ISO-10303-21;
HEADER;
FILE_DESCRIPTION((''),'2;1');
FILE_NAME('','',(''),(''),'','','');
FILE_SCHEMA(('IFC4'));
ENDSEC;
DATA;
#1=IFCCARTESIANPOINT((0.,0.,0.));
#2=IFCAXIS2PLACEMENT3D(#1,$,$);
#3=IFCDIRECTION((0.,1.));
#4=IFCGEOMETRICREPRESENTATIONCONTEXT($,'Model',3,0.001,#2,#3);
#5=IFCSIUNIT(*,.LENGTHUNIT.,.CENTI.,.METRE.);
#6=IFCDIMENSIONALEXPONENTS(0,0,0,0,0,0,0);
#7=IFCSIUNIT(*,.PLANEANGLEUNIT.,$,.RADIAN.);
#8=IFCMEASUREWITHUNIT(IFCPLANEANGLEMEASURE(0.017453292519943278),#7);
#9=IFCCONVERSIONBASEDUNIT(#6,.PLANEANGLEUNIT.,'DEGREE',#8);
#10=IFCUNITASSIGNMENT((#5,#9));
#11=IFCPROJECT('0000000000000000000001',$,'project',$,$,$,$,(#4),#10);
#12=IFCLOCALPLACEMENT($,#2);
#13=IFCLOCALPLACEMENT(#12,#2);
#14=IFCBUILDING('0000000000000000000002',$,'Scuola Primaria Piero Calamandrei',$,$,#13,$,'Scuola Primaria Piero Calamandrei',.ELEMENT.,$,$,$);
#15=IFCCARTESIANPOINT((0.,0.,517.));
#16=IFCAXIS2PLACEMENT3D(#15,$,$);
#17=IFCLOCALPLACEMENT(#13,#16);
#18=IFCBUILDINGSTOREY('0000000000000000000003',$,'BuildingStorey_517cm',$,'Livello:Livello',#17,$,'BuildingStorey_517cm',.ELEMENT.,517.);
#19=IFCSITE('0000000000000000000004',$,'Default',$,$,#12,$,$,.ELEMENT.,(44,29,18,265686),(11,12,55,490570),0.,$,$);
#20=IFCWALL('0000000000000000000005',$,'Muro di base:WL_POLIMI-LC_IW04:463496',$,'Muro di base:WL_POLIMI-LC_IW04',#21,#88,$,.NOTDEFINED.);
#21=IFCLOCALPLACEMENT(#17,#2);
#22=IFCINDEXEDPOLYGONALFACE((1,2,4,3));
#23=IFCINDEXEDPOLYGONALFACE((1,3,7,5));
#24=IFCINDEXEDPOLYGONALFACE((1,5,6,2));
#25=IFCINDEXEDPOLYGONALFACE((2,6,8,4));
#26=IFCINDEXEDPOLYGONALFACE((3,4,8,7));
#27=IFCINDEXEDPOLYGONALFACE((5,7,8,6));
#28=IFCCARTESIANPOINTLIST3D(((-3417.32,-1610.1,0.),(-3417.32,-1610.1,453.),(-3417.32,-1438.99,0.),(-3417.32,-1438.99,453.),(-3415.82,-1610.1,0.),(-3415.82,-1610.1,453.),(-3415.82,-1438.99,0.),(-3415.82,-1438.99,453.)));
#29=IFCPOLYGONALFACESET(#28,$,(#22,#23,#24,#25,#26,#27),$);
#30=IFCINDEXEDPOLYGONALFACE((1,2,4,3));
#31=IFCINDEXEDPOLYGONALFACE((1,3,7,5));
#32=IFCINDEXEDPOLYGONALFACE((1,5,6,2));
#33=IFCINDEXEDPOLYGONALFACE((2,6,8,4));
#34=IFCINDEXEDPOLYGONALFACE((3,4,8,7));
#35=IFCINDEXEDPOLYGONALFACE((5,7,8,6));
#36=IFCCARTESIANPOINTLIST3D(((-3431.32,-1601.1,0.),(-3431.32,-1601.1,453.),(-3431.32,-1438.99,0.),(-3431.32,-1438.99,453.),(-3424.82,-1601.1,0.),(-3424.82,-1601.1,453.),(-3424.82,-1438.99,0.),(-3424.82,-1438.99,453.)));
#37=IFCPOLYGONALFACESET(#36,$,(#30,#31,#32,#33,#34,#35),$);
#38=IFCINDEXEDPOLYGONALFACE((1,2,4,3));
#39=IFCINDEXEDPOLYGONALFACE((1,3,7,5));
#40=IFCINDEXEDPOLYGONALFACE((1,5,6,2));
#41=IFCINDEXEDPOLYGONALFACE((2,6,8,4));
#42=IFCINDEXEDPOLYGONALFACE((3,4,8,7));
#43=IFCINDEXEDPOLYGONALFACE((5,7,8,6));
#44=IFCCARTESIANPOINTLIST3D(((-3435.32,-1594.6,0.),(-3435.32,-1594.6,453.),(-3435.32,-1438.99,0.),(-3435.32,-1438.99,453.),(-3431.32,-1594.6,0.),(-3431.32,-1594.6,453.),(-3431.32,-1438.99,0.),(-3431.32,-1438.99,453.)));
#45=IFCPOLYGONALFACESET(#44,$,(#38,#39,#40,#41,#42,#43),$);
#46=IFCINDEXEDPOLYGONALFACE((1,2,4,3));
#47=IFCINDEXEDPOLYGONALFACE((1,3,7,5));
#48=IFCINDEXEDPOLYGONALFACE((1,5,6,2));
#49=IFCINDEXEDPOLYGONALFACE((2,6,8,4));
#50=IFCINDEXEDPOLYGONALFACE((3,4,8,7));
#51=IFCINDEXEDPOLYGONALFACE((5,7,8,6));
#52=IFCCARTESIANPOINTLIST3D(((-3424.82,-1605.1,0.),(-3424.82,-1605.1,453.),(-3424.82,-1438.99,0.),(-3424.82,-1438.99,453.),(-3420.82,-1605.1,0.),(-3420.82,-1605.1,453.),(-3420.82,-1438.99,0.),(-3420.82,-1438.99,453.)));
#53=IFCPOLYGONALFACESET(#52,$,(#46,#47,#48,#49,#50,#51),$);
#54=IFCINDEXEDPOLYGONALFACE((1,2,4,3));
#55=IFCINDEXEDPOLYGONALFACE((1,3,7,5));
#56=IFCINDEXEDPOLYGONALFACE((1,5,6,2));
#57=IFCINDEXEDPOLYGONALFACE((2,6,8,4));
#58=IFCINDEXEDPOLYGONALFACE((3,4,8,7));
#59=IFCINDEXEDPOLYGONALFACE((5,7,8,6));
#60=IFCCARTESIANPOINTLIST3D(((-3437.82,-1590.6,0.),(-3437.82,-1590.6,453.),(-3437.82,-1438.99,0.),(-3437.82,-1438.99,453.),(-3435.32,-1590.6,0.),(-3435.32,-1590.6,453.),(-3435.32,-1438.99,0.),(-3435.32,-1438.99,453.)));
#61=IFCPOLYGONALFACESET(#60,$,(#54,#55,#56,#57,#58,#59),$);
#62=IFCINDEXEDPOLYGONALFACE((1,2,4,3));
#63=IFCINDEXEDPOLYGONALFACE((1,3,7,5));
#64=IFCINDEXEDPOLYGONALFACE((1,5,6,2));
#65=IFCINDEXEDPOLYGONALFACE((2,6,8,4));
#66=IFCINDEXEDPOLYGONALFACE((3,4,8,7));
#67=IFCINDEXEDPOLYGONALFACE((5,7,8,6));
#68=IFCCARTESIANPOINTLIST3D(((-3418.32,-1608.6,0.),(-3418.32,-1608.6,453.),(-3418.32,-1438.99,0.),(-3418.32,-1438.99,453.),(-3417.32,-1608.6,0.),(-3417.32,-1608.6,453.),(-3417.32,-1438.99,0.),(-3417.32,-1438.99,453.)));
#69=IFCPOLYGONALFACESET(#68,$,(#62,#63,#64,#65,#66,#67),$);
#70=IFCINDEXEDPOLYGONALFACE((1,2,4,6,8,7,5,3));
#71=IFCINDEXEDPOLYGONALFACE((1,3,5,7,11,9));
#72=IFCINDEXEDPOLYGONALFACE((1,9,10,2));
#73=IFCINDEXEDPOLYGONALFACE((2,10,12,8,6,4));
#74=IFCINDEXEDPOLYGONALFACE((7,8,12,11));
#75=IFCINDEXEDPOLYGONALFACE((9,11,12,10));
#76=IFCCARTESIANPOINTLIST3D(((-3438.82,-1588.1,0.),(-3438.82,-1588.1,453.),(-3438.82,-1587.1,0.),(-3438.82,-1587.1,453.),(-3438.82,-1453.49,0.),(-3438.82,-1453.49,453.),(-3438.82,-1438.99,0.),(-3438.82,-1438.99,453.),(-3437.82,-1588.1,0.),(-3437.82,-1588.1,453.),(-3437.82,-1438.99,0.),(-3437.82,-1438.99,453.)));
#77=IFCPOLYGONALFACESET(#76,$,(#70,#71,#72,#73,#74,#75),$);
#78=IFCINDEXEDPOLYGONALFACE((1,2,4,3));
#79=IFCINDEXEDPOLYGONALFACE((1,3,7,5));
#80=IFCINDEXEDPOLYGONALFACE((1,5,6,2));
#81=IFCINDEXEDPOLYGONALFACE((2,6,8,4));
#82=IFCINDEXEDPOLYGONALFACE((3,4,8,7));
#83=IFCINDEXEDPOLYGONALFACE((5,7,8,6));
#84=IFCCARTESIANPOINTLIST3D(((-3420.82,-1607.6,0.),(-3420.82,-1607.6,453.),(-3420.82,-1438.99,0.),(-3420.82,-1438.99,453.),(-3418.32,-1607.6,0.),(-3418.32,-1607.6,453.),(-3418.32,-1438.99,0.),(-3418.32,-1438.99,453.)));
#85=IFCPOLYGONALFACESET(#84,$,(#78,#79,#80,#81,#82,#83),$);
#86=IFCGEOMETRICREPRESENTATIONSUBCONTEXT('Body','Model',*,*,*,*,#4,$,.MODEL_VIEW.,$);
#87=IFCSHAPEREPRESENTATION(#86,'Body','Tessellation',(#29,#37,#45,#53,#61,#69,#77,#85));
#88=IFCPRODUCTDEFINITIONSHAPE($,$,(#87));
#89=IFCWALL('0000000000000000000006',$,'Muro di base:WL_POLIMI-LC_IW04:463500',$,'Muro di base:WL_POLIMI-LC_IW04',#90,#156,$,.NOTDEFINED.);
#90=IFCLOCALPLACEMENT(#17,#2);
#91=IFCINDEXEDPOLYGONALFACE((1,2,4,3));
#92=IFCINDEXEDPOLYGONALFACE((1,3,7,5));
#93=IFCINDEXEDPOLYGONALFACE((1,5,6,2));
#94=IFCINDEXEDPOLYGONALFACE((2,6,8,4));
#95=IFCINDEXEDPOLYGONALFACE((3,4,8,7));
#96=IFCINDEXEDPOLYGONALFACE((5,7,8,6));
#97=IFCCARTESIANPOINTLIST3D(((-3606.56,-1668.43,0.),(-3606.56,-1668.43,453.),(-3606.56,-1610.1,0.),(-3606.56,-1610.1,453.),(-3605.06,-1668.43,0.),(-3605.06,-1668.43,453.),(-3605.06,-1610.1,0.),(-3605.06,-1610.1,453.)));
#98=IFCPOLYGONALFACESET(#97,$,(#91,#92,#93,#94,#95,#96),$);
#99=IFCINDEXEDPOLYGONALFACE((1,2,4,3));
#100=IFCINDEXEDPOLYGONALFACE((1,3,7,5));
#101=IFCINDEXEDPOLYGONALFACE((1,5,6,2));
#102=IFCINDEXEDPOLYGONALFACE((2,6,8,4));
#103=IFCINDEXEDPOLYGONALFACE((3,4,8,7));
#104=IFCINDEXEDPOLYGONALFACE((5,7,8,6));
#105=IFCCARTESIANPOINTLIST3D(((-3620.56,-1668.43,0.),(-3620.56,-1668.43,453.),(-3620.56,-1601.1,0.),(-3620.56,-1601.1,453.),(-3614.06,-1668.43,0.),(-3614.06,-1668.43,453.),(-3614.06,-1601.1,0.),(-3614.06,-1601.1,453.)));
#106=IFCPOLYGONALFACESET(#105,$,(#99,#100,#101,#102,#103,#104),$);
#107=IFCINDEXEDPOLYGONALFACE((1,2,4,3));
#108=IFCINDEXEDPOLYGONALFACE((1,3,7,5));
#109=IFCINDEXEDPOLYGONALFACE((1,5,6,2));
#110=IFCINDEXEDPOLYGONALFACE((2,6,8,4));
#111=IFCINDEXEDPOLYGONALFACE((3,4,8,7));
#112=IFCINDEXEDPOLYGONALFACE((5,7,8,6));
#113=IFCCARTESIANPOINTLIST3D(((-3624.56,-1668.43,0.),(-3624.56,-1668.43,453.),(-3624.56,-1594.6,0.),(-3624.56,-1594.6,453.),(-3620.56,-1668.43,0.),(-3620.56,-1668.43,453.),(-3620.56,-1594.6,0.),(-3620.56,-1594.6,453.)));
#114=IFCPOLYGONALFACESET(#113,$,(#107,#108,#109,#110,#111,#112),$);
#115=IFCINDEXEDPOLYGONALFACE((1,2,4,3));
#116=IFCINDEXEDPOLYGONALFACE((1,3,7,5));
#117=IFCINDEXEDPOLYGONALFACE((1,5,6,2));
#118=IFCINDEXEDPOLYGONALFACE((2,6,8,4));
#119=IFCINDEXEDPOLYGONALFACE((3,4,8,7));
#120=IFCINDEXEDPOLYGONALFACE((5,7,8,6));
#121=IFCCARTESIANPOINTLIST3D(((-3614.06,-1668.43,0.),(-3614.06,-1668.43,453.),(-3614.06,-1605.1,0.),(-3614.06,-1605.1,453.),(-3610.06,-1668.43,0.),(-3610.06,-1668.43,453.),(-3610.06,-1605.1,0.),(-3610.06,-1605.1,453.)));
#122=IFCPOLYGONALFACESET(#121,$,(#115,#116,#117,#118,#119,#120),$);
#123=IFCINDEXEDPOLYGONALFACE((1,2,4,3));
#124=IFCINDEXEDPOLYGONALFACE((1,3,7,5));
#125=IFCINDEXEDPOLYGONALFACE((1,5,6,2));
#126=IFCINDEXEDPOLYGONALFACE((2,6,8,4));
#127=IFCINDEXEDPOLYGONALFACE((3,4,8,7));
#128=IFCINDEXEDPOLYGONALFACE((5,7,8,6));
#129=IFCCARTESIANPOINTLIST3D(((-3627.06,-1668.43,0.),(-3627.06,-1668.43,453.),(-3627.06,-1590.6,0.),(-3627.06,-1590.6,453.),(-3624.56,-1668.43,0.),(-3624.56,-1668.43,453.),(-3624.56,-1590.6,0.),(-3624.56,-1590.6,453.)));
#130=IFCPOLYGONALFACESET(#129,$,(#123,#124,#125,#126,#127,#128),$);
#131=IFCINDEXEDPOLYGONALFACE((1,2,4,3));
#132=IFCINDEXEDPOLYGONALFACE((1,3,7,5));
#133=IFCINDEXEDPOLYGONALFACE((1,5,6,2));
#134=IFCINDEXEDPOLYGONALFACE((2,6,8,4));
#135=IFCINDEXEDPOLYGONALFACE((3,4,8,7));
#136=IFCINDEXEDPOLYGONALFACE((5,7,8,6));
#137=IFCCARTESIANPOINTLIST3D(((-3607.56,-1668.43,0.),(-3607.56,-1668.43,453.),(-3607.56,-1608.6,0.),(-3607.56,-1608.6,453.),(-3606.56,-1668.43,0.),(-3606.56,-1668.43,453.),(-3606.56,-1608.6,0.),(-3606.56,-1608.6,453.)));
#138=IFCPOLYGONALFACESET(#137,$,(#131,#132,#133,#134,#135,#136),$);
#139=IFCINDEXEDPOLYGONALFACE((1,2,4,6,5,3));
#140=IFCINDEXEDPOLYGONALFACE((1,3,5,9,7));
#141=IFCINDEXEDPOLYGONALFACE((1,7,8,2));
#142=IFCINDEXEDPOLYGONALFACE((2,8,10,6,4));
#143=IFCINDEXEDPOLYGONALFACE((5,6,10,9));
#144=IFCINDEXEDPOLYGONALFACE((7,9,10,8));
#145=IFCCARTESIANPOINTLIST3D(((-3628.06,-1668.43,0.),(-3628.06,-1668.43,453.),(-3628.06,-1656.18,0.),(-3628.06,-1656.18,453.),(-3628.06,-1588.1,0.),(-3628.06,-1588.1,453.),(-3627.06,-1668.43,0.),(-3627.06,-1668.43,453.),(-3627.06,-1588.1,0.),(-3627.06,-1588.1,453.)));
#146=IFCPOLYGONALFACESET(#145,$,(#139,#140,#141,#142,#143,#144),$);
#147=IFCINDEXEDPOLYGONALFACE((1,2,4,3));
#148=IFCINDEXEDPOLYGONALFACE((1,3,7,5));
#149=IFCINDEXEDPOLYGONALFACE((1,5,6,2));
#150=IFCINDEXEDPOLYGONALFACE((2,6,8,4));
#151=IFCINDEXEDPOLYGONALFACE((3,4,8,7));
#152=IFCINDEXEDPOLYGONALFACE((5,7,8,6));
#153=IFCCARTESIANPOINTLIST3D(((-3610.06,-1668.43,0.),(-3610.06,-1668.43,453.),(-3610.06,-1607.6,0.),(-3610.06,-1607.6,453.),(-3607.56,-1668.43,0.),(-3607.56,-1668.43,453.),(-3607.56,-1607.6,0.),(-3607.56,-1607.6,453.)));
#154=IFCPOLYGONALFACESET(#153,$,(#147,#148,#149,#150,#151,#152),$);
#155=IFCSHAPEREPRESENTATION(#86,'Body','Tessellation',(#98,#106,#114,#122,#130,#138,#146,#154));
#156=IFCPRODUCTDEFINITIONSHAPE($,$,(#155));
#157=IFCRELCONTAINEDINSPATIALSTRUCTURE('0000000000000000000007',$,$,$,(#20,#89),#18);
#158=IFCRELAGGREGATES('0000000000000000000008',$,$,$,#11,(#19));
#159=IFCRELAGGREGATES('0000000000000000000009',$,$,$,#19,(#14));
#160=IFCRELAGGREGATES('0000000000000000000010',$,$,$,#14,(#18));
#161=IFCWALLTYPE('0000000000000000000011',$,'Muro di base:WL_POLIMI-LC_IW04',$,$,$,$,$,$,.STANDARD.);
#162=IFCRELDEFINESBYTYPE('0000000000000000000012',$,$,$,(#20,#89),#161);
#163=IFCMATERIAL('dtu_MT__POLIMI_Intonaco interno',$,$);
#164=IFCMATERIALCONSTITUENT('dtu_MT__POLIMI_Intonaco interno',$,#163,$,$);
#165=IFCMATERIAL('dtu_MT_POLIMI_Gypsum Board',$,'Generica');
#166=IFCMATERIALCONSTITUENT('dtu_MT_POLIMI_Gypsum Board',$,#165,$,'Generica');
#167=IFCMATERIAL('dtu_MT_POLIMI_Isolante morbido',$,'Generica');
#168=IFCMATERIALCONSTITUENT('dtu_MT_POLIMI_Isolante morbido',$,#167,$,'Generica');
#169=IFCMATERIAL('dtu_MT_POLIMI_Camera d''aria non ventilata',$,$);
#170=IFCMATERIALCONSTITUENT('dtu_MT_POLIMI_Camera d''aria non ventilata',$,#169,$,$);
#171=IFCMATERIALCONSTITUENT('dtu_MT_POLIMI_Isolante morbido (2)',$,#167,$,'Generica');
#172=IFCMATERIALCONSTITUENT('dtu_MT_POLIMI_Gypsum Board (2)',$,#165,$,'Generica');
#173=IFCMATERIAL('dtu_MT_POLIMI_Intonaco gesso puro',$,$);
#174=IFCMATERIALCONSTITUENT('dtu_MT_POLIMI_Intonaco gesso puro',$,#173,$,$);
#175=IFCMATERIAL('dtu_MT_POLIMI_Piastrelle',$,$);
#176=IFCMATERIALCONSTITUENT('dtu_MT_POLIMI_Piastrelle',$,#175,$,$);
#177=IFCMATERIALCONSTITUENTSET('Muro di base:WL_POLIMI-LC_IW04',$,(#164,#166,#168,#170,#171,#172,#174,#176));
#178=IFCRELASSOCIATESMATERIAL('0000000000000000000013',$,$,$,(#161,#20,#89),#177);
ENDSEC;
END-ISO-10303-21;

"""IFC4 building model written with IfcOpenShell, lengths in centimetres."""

from ifc_helpers import new_model, entity, si_unit, converted_unit, direction, frame, origin, place, context, subcontext, project, spatial, indexed_curve, outline, extrude, material, constituent, constituent_set, type_object, element, save


model = new_model("IFC4")

# Units and contexts
model_context = context("Model", 3, precision=0.001, world=origin(), true_north=direction((0.0, 1.0)))
body_context = subcontext(model_context, "Body", "Model", "MODEL_VIEW")
ifc_project = project(units=[si_unit("LENGTHUNIT", "METRE", prefix="CENTI"), converted_unit("PLANEANGLEUNIT", "DEGREE", entity("IfcPlaneAngleMeasure", 0.017453292519943278), si_unit("PLANEANGLEUNIT", "RADIAN"), dimensions=[0, 0, 0, 0, 0, 0, 0])], contexts=[model_context])

# Site, building, storey
site_placement = place(None, origin())
site = spatial("IfcSite", under=ifc_project, at=site_placement, Name="Default", CompositionType="ELEMENT", RefLatitude=(44, 29, 18, 265686), RefLongitude=(11, 12, 55, 490570), RefElevation=0.0)
building_placement = place(site_placement, origin())
building = spatial("IfcBuilding", under=site, at=building_placement, Name="Scuola Primaria Piero Calamandrei", LongName="Scuola Primaria Piero Calamandrei", CompositionType="ELEMENT")
storey_placement = place(building_placement, frame((0.0, 0.0, 517.0)))
storey = spatial("IfcBuildingStorey", under=building, at=storey_placement, Name="BuildingStorey_517cm", ObjectType="Livello:Livello", LongName="BuildingStorey_517cm", CompositionType="ELEMENT", Elevation=517.0)

# Shared definitions
ifc_material_1 = material(Name="dtu_MT_POLIMI_Isolante morbido", Category="Generica")
ifc_material_2 = material(Name="dtu_MT_POLIMI_Gypsum Board", Category="Generica")
ifc_material_3 = material(Name="dtu_MT__POLIMI_Intonaco interno")

# Wall
ifc_constituent_1 = constituent(ifc_material_3, Name="dtu_MT__POLIMI_Intonaco interno")
ifc_constituent_2 = constituent(ifc_material_2, Name="dtu_MT_POLIMI_Gypsum Board", Category="Generica")
ifc_constituent_3 = constituent(ifc_material_1, Name="dtu_MT_POLIMI_Isolante morbido", Category="Generica")
ifc_material_4 = material(Name="dtu_MT_POLIMI_Camera d'aria non ventilata")
ifc_constituent_4 = constituent(ifc_material_4, Name="dtu_MT_POLIMI_Camera d'aria non ventilata")
ifc_constituent_5 = constituent(ifc_material_1, Name="dtu_MT_POLIMI_Isolante morbido (2)", Category="Generica")
ifc_constituent_6 = constituent(ifc_material_2, Name="dtu_MT_POLIMI_Gypsum Board (2)", Category="Generica")
ifc_material_5 = material(Name="dtu_MT_POLIMI_Intonaco gesso puro")
ifc_constituent_7 = constituent(ifc_material_5, Name="dtu_MT_POLIMI_Intonaco gesso puro")
ifc_material_6 = material(Name="dtu_MT_POLIMI_Piastrelle")
ifc_constituent_8 = constituent(ifc_material_6, Name="dtu_MT_POLIMI_Piastrelle")
ifc_constituent_set_1 = constituent_set(constituents=[ifc_constituent_1, ifc_constituent_2, ifc_constituent_3, ifc_constituent_4, ifc_constituent_5, ifc_constituent_6, ifc_constituent_7, ifc_constituent_8], Name="Muro di base:WL_POLIMI-LC_IW04")
wall_type_1 = type_object("IfcWallType", Name="Muro di base:WL_POLIMI-LC_IW04", PredefinedType="STANDARD", material=ifc_constituent_set_1)
wall_1_placement = place(storey_placement, frame((-3427.32, -1610.1, 0.0), z_axis=(0.0, 0.0, 1.0), x_axis=(0.0, 1.0, 0.0)))
element("IfcWall", 1, at=wall_1_placement, inside=storey, type_object=wall_type_1, material=ifc_constituent_set_1, Name="Muro di base:WL_POLIMI-LC_IW04:463496", ObjectType="Muro di base:WL_POLIMI-LC_IW04", PredefinedType="NOTDEFINED", context=body_context, shape_type="SweptSolid", body=[
    extrude(outline(indexed_curve([(-0.75, -85.55), (0.75, -85.55), (0.75, 85.55), (-0.75, 85.55), (-0.75, -85.55)], self_intersect=False)), frame((85.55, -10.75, 0.0), z_axis=(0.0, 0.0, 1.0), x_axis=(0.0, 1.0, 0.0)), (0.0, 0.0, 1.0), 453.0),
    extrude(outline(indexed_curve([(-81.05, -3.25), (81.05, -3.25), (81.05, 3.25), (-81.05, 3.25), (-81.05, -3.25)], self_intersect=False)), frame((90.05, 0.75, 0.0)), (0.0, 0.0, 1.0), 453.0),
    extrude(outline(indexed_curve([(-77.8, -2.0), (77.8, -2.0), (77.8, 2.0), (-77.8, 2.0), (-77.8, -2.0)], self_intersect=False)), frame((93.3, 6.0, 0.0)), (0.0, 0.0, 1.0), 453.0),
    extrude(outline(indexed_curve([(-83.05, -2.0), (83.05, -2.0), (83.05, 2.0), (-83.05, 2.0), (-83.05, -2.0)], self_intersect=False)), frame((88.05, -4.5, 0.0)), (0.0, 0.0, 1.0), 453.0),
    extrude(outline(indexed_curve([(-75.8, -1.25), (75.8, -1.25), (75.8, 1.25), (-75.8, 1.25), (-75.8, -1.25)], self_intersect=False)), frame((95.3, 9.25, 0.0)), (0.0, 0.0, 1.0), 453.0),
    extrude(outline(indexed_curve([(-84.8, -0.5), (84.8, -0.5), (84.8, 0.5), (-84.8, 0.5), (-84.8, -0.5)], self_intersect=False)), frame((86.3, -9.5, 0.0)), (0.0, 0.0, 1.0), 453.0),
    extrude(outline(indexed_curve([(-62.3, -0.33), (71.3, -0.33), (72.3, -0.33), (72.3, 0.67), (-76.8, 0.67), (-76.8, -0.33), (-62.3, -0.33)], self_intersect=False)), frame((94.3, 11.17, 0.0), z_axis=(0.0, 0.0, 1.0), x_axis=(-1.0, 0.0, 0.0)), (0.0, 0.0, 1.0), 453.0),
    extrude(outline(indexed_curve([(-84.3, -1.25), (84.3, -1.25), (84.3, 1.25), (-84.3, 1.25), (-84.3, -1.25)], self_intersect=False)), frame((86.8, -7.75, 0.0)), (0.0, 0.0, 1.0), 453.0),
])

# Wall
wall_2_placement = place(storey_placement, frame((-3616.56, -1668.43, 0.0), z_axis=(0.0, 0.0, 1.0), x_axis=(0.0, 1.0, 0.0)))
element("IfcWall", 2, at=wall_2_placement, inside=storey, type_object=wall_type_1, material=ifc_constituent_set_1, Name="Muro di base:WL_POLIMI-LC_IW04:463500", ObjectType="Muro di base:WL_POLIMI-LC_IW04", PredefinedType="NOTDEFINED", context=body_context, shape_type="SweptSolid", body=[
    extrude(outline(indexed_curve([(-0.75, -29.16), (0.75, -29.16), (0.75, 29.16), (-0.75, 29.16), (-0.75, -29.16)], self_intersect=False)), frame((29.16, -10.75, 0.0), z_axis=(0.0, 0.0, 1.0), x_axis=(0.0, 1.0, 0.0)), (0.0, 0.0, 1.0), 453.0),
    extrude(outline(indexed_curve([(-33.66, -3.25), (33.66, -3.25), (33.66, 3.25), (-33.66, 3.25), (-33.66, -3.25)], self_intersect=False)), frame((33.66, 0.75, 0.0)), (0.0, 0.0, 1.0), 453.0),
    extrude(outline(indexed_curve([(-36.91, -2.0), (36.91, -2.0), (36.91, 2.0), (-36.91, 2.0), (-36.91, -2.0)], self_intersect=False)), frame((36.91, 6.0, 0.0)), (0.0, 0.0, 1.0), 453.0),
    extrude(outline(indexed_curve([(-31.66, -2.0), (31.66, -2.0), (31.66, 2.0), (-31.66, 2.0), (-31.66, -2.0)], self_intersect=False)), frame((31.66, -4.5, 0.0)), (0.0, 0.0, 1.0), 453.0),
    extrude(outline(indexed_curve([(-38.91, -1.25), (38.91, -1.25), (38.91, 1.25), (-38.91, 1.25), (-38.91, -1.25)], self_intersect=False)), frame((38.91, 9.25, 0.0)), (0.0, 0.0, 1.0), 453.0),
    extrude(outline(indexed_curve([(-29.91, -0.5), (29.91, -0.5), (29.91, 0.5), (-29.91, 0.5), (-29.91, -0.5)], self_intersect=False)), frame((29.91, -9.5, 0.0)), (0.0, 0.0, 1.0), 453.0),
    extrude(outline(indexed_curve([(22.33, -0.4), (34.58, -0.4), (34.58, 0.6), (-45.75, 0.6), (-45.75, -0.4), (22.33, -0.4)], self_intersect=False)), frame((34.58, 11.1, 0.0), z_axis=(0.0, 0.0, 1.0), x_axis=(-1.0, 0.0, 0.0)), (0.0, 0.0, 1.0), 453.0),
    extrude(outline(indexed_curve([(-30.41, -1.25), (30.41, -1.25), (30.41, 1.25), (-30.41, 1.25), (-30.41, -1.25)], self_intersect=False)), frame((30.41, -7.75, 0.0)), (0.0, 0.0, 1.0), 453.0),
])

save(model, "model.ifc")
